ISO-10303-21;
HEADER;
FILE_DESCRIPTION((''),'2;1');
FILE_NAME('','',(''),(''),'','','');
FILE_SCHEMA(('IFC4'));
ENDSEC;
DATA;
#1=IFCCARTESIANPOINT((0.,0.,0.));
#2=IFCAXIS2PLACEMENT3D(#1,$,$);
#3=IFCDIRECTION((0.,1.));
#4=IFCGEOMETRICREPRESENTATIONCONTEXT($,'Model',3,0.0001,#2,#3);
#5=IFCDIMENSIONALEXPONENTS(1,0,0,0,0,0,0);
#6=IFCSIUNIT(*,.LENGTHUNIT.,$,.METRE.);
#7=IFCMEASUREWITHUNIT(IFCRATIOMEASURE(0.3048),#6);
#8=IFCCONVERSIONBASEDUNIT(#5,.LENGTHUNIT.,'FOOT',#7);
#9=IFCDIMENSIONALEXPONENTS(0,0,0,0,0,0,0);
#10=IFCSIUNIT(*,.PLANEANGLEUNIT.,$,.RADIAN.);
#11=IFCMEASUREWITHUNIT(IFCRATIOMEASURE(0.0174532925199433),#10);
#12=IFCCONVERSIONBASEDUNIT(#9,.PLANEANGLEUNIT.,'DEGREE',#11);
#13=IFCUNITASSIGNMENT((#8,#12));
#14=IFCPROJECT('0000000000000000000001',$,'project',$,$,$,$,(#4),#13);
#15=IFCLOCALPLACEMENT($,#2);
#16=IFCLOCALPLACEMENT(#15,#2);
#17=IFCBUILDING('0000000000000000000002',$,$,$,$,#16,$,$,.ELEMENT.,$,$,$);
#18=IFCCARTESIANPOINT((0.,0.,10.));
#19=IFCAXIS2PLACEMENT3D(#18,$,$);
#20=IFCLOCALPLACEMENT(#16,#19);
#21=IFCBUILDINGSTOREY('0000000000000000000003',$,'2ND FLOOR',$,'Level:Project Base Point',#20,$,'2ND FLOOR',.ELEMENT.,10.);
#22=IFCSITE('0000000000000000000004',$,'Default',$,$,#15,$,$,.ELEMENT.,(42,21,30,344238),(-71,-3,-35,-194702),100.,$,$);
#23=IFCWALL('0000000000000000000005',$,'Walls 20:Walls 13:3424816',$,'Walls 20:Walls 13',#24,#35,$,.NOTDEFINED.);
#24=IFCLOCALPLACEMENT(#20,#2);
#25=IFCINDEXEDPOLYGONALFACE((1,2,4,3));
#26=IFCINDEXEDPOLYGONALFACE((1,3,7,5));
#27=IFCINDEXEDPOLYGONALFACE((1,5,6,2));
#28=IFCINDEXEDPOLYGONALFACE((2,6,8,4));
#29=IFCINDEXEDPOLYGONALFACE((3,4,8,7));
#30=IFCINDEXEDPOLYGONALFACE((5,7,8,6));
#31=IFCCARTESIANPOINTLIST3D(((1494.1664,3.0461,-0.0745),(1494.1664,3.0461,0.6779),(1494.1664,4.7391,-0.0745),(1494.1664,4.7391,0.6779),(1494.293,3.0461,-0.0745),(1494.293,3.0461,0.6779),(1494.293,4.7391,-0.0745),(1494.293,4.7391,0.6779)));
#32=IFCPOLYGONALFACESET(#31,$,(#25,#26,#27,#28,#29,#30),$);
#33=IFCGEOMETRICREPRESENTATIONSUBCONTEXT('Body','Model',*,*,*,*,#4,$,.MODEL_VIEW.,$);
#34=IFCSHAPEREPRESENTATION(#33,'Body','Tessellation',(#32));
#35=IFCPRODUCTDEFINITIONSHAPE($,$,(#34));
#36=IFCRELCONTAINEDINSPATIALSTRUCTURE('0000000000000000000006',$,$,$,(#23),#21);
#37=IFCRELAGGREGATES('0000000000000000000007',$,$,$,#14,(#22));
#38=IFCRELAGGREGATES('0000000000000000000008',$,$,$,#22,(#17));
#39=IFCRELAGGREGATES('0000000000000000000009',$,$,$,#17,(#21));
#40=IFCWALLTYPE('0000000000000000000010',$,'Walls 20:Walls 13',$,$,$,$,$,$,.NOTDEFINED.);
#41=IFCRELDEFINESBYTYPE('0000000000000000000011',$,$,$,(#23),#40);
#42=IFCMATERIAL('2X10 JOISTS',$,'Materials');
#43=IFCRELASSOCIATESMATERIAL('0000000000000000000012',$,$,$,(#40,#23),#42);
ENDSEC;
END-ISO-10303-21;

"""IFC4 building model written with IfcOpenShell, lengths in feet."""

from ifc_helpers import new_model, entity, si_unit, converted_unit, direction, frame, frame_2d, origin, place, context, subcontext, project, spatial, rectangle, extrude, material, type_object, element, save


model = new_model("IFC4")

# Units and contexts
model_context = context("Model", 3, precision=0.0001, world=origin(), true_north=direction((0.0, 1.0)))
body_context = subcontext(model_context, "Body", "Model", "MODEL_VIEW")
ifc_project = project(units=[converted_unit("LENGTHUNIT", "FOOT", entity("IfcRatioMeasure", 0.3048), si_unit("LENGTHUNIT", "METRE"), dimensions=[1, 0, 0, 0, 0, 0, 0]), converted_unit("PLANEANGLEUNIT", "DEGREE", entity("IfcRatioMeasure", 0.0174532925199433), si_unit("PLANEANGLEUNIT", "RADIAN"), dimensions=[0, 0, 0, 0, 0, 0, 0])], contexts=[model_context])

# Site, building, storey
site_placement = place(None, origin())
site = spatial("IfcSite", under=ifc_project, at=site_placement, Name="Default", CompositionType="ELEMENT", RefLatitude=(42, 21, 30, 344238), RefLongitude=(-71, -3, -35, -194702), RefElevation=100.0)
building_placement = place(site_placement, origin())
building = spatial("IfcBuilding", under=site, at=building_placement, CompositionType="ELEMENT")
storey_placement = place(building_placement, frame((0.0, 0.0, 10.0)))
storey = spatial("IfcBuildingStorey", under=building, at=storey_placement, Name="2ND FLOOR", ObjectType="Level:Project Base Point", LongName="2ND FLOOR", CompositionType="ELEMENT", Elevation=10.0)

# Wall
ifc_material_1 = material(Name="2X10 JOISTS", Category="Materials")
wall_type = type_object("IfcWallType", Name="Walls 20:Walls 13", PredefinedType="NOTDEFINED", material=ifc_material_1)
wall_placement = place(storey_placement, frame((1494.1664, 3.0461, -0.0745), z_axis=(0.0, 0.0, 1.0), x_axis=(0.0, 1.0, 0.0)))
element("IfcWall", 1, at=wall_placement, inside=storey, type_object=wall_type, material=ifc_material_1, Name="Walls 20:Walls 13:3424816", ObjectType="Walls 20:Walls 13", PredefinedType="NOTDEFINED", context=body_context, shape_type="SweptSolid", body=[
    extrude(rectangle(XDim=1.693, YDim=0.1266, at=frame_2d((0.0, 0.0), x_axis=(1.0, 0.0))), frame((0.8465, -0.0633, 0.0)), (0.0, 0.0, 1.0), 0.7524),
])

save(model, "model.ifc")
